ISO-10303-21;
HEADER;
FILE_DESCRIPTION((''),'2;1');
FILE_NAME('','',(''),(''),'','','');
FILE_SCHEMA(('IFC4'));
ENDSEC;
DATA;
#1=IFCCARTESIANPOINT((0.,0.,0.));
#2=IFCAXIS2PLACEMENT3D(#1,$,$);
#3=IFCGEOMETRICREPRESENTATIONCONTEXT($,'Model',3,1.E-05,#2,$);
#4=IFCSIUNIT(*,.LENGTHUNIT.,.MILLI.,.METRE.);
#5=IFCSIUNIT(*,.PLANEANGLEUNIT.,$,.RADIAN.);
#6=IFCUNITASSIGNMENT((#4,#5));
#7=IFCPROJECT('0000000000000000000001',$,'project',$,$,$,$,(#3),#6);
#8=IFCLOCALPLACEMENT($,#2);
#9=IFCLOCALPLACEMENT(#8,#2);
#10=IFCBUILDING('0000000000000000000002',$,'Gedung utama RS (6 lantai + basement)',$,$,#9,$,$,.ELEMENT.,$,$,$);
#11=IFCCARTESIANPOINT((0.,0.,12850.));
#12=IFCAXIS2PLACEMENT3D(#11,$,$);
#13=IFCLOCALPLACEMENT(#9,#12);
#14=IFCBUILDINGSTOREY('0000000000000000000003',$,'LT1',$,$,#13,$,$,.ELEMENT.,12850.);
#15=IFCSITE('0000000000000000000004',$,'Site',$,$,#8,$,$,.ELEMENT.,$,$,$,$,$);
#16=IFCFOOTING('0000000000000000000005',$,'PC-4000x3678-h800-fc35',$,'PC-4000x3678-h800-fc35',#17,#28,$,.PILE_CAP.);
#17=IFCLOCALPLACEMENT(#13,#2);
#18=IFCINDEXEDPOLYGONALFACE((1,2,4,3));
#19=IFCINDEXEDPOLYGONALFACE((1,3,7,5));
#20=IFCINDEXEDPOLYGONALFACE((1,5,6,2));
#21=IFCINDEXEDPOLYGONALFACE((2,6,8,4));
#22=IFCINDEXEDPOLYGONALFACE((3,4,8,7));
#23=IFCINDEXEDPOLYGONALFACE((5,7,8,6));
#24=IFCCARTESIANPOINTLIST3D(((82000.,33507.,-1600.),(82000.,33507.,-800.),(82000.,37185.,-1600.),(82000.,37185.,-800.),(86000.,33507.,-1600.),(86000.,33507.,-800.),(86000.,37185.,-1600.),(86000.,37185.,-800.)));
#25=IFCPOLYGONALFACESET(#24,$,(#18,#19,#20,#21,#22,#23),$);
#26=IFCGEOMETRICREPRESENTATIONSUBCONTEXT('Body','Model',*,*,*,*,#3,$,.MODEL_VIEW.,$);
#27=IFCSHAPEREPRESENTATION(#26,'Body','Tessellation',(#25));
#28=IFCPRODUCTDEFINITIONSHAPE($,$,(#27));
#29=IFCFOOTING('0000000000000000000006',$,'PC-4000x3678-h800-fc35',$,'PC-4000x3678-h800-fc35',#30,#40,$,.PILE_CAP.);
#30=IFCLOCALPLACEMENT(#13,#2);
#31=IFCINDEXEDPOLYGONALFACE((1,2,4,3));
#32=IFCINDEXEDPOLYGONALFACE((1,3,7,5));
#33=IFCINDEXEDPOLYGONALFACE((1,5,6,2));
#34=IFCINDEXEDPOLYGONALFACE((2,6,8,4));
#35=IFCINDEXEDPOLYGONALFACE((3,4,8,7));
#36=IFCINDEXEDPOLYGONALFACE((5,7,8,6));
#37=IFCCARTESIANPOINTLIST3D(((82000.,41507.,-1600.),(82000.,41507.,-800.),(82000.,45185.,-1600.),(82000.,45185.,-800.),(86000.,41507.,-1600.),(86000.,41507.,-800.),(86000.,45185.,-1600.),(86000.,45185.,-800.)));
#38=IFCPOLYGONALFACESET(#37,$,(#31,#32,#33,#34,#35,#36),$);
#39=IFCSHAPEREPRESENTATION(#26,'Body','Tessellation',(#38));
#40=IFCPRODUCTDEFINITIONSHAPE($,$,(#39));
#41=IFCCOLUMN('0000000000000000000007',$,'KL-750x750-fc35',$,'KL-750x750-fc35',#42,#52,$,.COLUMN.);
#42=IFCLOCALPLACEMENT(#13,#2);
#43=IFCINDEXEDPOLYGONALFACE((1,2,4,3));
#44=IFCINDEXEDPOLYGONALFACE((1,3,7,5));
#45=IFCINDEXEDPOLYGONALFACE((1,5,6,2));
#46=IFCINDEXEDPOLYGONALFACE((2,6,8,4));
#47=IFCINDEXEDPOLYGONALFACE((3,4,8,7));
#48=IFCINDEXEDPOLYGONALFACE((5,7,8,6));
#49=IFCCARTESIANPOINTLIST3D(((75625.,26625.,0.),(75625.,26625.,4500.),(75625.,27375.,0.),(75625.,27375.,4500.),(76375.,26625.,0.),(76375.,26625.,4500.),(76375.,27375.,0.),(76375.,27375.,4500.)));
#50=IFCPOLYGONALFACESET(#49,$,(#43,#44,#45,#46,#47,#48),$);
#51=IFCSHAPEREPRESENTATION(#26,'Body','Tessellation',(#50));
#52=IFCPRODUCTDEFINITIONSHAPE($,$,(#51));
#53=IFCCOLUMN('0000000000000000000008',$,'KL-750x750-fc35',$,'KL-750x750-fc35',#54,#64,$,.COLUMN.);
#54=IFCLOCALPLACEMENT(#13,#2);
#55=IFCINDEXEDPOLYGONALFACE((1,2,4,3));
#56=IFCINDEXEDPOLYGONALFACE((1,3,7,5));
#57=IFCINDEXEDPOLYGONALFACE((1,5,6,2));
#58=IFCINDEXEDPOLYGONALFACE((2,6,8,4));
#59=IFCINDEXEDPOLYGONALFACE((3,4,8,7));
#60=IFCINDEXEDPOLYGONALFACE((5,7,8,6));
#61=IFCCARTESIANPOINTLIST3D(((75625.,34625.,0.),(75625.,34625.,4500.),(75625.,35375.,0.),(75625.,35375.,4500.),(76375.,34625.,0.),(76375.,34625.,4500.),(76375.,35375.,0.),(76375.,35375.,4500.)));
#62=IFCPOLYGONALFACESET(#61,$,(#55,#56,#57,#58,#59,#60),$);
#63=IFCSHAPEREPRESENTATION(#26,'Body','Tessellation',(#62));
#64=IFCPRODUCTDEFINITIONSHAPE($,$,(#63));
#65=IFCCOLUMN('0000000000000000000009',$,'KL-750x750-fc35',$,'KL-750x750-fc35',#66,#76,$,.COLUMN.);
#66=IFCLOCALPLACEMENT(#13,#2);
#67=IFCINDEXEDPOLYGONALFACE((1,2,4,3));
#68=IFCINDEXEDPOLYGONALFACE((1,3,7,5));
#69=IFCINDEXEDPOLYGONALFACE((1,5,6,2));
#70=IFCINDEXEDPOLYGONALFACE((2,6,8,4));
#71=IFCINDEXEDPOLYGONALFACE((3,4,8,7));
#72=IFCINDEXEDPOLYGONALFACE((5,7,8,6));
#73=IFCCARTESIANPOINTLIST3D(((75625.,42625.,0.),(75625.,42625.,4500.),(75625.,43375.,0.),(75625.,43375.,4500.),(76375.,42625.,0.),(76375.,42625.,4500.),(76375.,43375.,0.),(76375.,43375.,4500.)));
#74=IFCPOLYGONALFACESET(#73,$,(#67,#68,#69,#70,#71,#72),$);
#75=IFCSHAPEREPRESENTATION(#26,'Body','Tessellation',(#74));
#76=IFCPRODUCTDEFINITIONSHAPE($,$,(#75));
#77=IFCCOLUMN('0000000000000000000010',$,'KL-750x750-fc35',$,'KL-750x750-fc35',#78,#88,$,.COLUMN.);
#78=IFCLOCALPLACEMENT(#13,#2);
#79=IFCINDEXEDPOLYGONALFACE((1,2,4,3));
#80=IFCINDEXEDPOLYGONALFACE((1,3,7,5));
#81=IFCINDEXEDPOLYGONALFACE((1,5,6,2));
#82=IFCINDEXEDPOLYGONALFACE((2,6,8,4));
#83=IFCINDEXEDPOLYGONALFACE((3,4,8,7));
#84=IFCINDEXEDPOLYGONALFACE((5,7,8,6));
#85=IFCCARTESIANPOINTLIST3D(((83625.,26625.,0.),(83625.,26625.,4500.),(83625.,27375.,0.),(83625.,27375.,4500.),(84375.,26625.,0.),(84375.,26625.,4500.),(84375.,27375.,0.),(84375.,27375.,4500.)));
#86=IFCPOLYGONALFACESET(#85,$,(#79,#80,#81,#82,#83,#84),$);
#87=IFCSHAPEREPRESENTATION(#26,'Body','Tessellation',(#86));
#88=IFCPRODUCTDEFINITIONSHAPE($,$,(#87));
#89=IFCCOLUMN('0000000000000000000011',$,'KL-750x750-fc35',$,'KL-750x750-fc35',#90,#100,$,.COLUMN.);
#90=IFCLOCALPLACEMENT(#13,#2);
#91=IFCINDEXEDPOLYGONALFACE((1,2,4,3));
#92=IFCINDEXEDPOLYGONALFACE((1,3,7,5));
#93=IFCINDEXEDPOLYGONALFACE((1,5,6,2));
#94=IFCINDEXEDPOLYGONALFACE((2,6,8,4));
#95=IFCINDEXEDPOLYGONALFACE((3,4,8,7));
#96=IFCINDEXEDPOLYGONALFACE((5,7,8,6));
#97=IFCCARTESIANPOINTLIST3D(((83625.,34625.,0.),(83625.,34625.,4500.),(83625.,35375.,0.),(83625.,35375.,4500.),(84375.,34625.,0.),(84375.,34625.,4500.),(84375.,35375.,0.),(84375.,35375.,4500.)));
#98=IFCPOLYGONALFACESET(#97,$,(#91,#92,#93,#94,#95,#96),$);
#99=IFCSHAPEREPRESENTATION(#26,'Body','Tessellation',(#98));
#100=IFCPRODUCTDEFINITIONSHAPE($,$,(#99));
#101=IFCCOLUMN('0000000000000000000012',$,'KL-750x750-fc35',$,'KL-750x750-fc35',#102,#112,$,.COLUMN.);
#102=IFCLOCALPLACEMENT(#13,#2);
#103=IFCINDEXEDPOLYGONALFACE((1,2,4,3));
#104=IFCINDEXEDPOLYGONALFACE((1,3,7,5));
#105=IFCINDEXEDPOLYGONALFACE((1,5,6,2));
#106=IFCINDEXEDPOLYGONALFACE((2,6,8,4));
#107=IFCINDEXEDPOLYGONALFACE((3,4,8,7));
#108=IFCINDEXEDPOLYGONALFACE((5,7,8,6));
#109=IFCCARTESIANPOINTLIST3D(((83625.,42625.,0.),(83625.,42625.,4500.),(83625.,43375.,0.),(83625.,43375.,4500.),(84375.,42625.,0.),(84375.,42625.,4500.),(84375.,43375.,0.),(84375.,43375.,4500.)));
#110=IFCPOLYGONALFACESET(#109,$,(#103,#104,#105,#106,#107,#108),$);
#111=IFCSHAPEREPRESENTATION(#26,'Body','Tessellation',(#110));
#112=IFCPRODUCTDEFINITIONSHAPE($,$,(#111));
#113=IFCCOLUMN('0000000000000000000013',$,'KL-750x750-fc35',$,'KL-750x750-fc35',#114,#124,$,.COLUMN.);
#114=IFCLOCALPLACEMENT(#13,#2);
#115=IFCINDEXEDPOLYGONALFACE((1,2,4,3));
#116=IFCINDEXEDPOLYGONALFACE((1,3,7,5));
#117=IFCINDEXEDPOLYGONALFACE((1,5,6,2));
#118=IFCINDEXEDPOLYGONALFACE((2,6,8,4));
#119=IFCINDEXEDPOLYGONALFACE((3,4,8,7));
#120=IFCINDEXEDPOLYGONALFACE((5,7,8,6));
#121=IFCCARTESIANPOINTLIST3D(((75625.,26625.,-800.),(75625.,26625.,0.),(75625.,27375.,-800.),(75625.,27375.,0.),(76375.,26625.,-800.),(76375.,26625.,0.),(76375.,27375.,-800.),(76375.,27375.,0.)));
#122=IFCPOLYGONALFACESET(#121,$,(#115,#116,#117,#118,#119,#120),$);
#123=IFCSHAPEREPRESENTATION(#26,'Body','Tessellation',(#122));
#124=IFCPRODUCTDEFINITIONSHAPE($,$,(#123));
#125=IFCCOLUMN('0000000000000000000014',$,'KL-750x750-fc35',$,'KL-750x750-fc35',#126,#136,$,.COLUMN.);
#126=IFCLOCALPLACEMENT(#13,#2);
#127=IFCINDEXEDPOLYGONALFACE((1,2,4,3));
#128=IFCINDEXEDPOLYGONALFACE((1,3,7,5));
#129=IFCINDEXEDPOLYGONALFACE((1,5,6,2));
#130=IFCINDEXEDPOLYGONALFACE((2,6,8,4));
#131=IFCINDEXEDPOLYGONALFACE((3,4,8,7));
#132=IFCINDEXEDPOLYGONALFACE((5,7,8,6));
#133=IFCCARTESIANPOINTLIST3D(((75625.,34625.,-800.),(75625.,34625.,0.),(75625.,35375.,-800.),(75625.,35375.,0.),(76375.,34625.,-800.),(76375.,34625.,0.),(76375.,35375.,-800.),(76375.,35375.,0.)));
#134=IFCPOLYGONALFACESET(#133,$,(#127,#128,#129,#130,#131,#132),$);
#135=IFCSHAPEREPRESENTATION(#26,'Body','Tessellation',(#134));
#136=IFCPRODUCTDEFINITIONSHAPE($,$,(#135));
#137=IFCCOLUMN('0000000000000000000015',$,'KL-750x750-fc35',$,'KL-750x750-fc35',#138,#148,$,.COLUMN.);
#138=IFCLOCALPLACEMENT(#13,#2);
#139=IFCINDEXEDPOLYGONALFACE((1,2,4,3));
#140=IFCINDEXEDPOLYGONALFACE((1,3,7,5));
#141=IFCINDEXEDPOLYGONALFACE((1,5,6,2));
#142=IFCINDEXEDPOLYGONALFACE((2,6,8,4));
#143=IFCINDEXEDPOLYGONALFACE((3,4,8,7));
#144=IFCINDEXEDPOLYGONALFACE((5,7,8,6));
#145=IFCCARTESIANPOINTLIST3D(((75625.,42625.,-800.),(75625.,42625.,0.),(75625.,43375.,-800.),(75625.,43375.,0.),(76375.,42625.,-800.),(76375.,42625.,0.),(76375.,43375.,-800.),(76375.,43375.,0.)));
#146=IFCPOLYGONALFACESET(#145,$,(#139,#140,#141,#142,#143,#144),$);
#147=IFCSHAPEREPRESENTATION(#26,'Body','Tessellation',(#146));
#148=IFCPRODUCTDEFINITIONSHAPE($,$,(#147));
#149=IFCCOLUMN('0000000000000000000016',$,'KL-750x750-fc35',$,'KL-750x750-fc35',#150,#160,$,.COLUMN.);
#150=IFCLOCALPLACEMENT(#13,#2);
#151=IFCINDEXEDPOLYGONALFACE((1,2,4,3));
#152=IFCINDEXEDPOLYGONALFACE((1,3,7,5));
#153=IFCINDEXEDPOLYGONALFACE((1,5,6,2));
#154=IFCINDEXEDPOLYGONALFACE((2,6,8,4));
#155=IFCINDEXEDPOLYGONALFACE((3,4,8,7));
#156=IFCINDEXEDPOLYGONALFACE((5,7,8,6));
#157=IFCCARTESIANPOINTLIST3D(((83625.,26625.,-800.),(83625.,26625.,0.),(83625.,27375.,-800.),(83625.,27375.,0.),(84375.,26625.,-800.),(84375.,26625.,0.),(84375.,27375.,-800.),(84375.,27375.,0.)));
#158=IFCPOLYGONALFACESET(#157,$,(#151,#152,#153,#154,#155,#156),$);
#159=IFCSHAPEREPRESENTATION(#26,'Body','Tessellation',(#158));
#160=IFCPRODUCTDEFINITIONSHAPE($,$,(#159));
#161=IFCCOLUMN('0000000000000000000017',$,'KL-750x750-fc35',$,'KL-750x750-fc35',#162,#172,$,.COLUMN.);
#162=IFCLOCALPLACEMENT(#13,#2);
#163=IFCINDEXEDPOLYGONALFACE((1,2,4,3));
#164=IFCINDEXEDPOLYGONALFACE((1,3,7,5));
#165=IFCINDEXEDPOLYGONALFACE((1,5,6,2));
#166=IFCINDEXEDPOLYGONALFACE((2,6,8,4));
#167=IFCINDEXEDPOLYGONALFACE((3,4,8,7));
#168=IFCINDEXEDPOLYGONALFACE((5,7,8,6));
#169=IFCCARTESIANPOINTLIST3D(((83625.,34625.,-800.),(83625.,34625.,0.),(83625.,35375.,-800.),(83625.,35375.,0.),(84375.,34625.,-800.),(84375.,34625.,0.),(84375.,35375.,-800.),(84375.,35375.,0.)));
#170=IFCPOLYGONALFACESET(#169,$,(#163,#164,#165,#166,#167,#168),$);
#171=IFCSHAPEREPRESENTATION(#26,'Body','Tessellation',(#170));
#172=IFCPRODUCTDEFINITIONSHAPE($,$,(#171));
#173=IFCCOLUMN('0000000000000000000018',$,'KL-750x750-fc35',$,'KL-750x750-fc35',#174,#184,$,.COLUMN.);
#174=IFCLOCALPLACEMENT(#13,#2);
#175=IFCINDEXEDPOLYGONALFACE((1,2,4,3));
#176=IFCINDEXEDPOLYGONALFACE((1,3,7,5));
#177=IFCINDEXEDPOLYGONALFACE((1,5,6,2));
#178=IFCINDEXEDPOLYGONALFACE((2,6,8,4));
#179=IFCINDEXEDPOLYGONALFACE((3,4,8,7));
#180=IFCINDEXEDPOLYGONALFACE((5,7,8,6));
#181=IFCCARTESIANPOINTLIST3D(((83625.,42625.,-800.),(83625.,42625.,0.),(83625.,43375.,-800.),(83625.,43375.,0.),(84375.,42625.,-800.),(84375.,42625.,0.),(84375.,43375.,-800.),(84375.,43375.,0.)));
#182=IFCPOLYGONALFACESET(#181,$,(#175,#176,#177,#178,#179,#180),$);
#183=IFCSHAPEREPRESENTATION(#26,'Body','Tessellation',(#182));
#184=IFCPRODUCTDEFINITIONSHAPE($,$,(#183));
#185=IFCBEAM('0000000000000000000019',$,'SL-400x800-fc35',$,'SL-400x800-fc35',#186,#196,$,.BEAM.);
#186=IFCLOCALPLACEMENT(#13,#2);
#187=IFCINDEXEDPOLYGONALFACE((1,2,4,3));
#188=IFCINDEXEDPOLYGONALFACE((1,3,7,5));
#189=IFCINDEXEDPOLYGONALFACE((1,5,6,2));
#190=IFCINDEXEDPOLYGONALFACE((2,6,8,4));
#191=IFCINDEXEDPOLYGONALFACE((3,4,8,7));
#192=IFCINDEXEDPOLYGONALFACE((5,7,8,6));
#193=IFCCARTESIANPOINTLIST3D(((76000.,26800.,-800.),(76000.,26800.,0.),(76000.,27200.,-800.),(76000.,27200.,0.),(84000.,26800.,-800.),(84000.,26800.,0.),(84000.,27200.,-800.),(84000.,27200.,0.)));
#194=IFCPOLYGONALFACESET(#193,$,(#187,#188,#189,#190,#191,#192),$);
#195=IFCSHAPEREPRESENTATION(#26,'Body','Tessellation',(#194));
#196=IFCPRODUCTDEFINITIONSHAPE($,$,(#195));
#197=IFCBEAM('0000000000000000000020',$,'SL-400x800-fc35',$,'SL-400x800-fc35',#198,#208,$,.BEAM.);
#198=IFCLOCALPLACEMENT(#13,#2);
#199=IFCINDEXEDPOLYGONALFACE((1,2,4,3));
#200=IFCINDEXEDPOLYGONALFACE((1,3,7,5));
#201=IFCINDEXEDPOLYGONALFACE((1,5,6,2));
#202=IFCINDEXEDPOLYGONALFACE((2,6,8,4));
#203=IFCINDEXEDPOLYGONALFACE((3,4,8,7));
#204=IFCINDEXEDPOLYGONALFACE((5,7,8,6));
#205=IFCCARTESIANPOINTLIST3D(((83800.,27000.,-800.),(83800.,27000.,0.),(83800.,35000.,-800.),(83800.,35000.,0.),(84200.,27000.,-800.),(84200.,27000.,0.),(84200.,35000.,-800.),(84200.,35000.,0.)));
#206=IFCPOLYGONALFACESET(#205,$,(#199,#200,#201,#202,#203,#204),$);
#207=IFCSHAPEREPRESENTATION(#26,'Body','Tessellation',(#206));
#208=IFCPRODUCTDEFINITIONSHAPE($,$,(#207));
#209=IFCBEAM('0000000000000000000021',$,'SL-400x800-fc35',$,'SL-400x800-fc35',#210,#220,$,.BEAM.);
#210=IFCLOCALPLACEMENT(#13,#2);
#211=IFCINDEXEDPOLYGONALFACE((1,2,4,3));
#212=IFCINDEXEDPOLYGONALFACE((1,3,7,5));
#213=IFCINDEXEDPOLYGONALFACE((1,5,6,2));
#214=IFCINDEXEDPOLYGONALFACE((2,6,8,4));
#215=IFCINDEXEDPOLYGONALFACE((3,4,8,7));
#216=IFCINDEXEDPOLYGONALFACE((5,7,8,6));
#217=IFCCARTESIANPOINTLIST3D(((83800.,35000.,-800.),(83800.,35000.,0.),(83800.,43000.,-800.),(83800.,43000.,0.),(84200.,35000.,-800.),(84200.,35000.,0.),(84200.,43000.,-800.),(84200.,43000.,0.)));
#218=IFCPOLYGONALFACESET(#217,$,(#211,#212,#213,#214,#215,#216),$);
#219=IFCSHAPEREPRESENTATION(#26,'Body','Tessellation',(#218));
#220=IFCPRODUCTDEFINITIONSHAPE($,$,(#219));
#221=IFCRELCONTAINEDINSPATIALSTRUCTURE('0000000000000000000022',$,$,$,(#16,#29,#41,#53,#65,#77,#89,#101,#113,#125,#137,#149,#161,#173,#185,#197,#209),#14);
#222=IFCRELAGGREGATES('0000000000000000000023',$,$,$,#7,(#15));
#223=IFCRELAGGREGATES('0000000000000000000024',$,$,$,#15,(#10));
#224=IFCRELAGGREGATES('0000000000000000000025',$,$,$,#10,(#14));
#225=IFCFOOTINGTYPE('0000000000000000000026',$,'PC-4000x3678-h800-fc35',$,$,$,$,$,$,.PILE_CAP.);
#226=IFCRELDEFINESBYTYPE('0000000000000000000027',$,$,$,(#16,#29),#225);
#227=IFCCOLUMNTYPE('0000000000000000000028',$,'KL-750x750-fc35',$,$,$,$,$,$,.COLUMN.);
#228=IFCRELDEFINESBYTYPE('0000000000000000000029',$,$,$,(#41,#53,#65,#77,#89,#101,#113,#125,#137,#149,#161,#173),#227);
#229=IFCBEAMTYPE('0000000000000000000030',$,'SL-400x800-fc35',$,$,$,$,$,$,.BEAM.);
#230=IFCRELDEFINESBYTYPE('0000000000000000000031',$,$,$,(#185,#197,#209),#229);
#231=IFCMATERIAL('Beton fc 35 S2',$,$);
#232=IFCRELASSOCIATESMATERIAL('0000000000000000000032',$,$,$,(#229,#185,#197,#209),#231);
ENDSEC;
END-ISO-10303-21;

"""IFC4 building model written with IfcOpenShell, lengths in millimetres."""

from ifc_helpers import new_model, si_unit, frame, origin, origin_2d, place, context, subcontext, project, spatial, rectangle, extrude, material, material_profile, profile_set, profile_usage, type_object, element, save


model = new_model("IFC4")

# Units and contexts
model_context = context("Model", 3, precision=1e-05, world=origin())
body_context = subcontext(model_context, "Body", "Model", "MODEL_VIEW")
ifc_project = project(units=[si_unit("LENGTHUNIT", "METRE", prefix="MILLI"), si_unit("PLANEANGLEUNIT", "RADIAN")], contexts=[model_context])

# Site, building, storey
site_placement = place(None, origin())
site = spatial("IfcSite", under=ifc_project, at=site_placement, Name="Site", CompositionType="ELEMENT")
building_placement = place(site_placement, origin())
building = spatial("IfcBuilding", under=site, at=building_placement, Name="Gedung utama RS (6 lantai + basement)", CompositionType="ELEMENT")
storey_placement = place(building_placement, frame((0.0, 0.0, 12850.0)))
storey = spatial("IfcBuildingStorey", under=building, at=storey_placement, Name="LT1", CompositionType="ELEMENT", Elevation=12850.0)

# Footings
ifc_material_profile_1 = material_profile(None, rectangle(XDim=4000.0, YDim=3678.0, at=origin_2d()), Name="PC-4000x3678-h800-fc35")
ifc_profile_set_1 = profile_set([ifc_material_profile_1], Name="PC-4000x3678-h800-fc35")
ifc_profile_usage_1 = profile_usage(ifc_profile_set_1, cardinal=5)
footing_type = type_object("IfcFootingType", Name="PC-4000x3678-h800-fc35", PredefinedType="PILE_CAP", material=ifc_profile_set_1)
for number, where, z_axis, x_axis, name in (
    (1, (84000.0, 35346.0, -1600.0), (0.0, 0.0, 1.0), (1.0, 0.0, 0.0), "PC-4000x3678-h800-fc35"),
    (2, (84000.0, 43346.0, -1600.0), (0.0, 0.0, 1.0), (1.0, 0.0, 0.0), "PC-4000x3678-h800-fc35"),
):
    element("IfcFooting", number, at=place(storey_placement, frame(where, z_axis=z_axis, x_axis=x_axis)), inside=storey, type_object=footing_type, material=ifc_profile_usage_1, Name=name, ObjectType="PC-4000x3678-h800-fc35", PredefinedType="PILE_CAP", context=body_context, shape_type="SweptSolid", body=[
        extrude(rectangle(XDim=4000.0, YDim=3678.0, at=origin_2d()), origin(), (0.0, 0.0, 1.0), 800.0),
    ])

# Columns
ifc_material_profile_2 = material_profile(None, rectangle(XDim=750.0, YDim=750.0, at=origin_2d()), Name="KL-750x750-fc35")
ifc_profile_set_2 = profile_set([ifc_material_profile_2], Name="KL-750x750-fc35")
ifc_profile_usage_2 = profile_usage(ifc_profile_set_2, cardinal=5)
column_type = type_object("IfcColumnType", Name="KL-750x750-fc35", PredefinedType="COLUMN", material=ifc_profile_set_2)
for number, where, z_axis, x_axis, name in (
    (3, (76000.0, 27000.0, 0.0), (0.0, 0.0, 1.0), (1.0, 0.0, 0.0), "KL-750x750-fc35"),
    (4, (76000.0, 35000.0, 0.0), (0.0, 0.0, 1.0), (1.0, 0.0, 0.0), "KL-750x750-fc35"),
    (5, (76000.0, 43000.0, 0.0), (0.0, 0.0, 1.0), (1.0, 0.0, 0.0), "KL-750x750-fc35"),
    (6, (84000.0, 27000.0, 0.0), (0.0, 0.0, 1.0), (1.0, 0.0, 0.0), "KL-750x750-fc35"),
    (7, (84000.0, 35000.0, 0.0), (0.0, 0.0, 1.0), (1.0, 0.0, 0.0), "KL-750x750-fc35"),
    (8, (84000.0, 43000.0, 0.0), (0.0, 0.0, 1.0), (1.0, 0.0, 0.0), "KL-750x750-fc35"),
):
    element("IfcColumn", number, at=place(storey_placement, frame(where, z_axis=z_axis, x_axis=x_axis)), inside=storey, type_object=column_type, material=ifc_profile_usage_2, Name=name, ObjectType="KL-750x750-fc35", PredefinedType="COLUMN", context=body_context, shape_type="SweptSolid", body=[
        extrude(rectangle(XDim=750.0, YDim=750.0, at=origin_2d()), origin(), (0.0, 0.0, 1.0), 4500.0),
    ])
for number, where, z_axis, x_axis, name in (
    (9, (76000.0, 27000.0, -800.0), (0.0, 0.0, 1.0), (1.0, 0.0, 0.0), "KL-750x750-fc35"),
    (10, (76000.0, 35000.0, -800.0), (0.0, 0.0, 1.0), (1.0, 0.0, 0.0), "KL-750x750-fc35"),
    (11, (76000.0, 43000.0, -800.0), (0.0, 0.0, 1.0), (1.0, 0.0, 0.0), "KL-750x750-fc35"),
    (12, (84000.0, 27000.0, -800.0), (0.0, 0.0, 1.0), (1.0, 0.0, 0.0), "KL-750x750-fc35"),
    (13, (84000.0, 35000.0, -800.0), (0.0, 0.0, 1.0), (1.0, 0.0, 0.0), "KL-750x750-fc35"),
    (14, (84000.0, 43000.0, -800.0), (0.0, 0.0, 1.0), (1.0, 0.0, 0.0), "KL-750x750-fc35"),
):
    element("IfcColumn", number, at=place(storey_placement, frame(where, z_axis=z_axis, x_axis=x_axis)), inside=storey, type_object=column_type, material=ifc_profile_usage_2, Name=name, ObjectType="KL-750x750-fc35", PredefinedType="COLUMN", context=body_context, shape_type="SweptSolid", body=[
        extrude(rectangle(XDim=750.0, YDim=750.0, at=origin_2d()), origin(), (0.0, 0.0, 1.0), 800.0),
    ])

# Beams
ifc_material = material(Name="Beton fc 35 S2")
ifc_material_profile_3 = material_profile(ifc_material, rectangle(XDim=400.0, YDim=800.0, at=origin_2d()), Name="SL-400x800-fc35")
ifc_profile_set_3 = profile_set([ifc_material_profile_3], Name="SL-400x800-fc35")
ifc_profile_usage_3 = profile_usage(ifc_profile_set_3, cardinal=8)
beam_type_1 = type_object("IfcBeamType", Name="SL-400x800-fc35", PredefinedType="BEAM", material=ifc_profile_set_3)
beam_1_placement = place(storey_placement, frame((76000.0, 27000.0, -400.0)))
element("IfcBeam", 15, at=beam_1_placement, inside=storey, type_object=beam_type_1, material=ifc_profile_usage_3, Name="SL-400x800-fc35", ObjectType="SL-400x800-fc35", PredefinedType="BEAM", context=body_context, shape_type="SweptSolid", body=[
    extrude(rectangle(XDim=400.0, YDim=800.0, at=origin_2d()), frame((0.0, 0.0, 0.0), z_axis=(1.0, 0.0, 0.0), x_axis=(0.0, 1.0, 0.0)), (0.0, 0.0, 1.0), 8000.0),
])
for number, where, name in (
    (16, (84000.0, 27000.0, -400.0), "SL-400x800-fc35"),
    (17, (84000.0, 35000.0, -400.0), "SL-400x800-fc35"),
):
    element("IfcBeam", number, at=place(storey_placement, frame(where)), inside=storey, type_object=beam_type_1, material=ifc_profile_usage_3, Name=name, ObjectType="SL-400x800-fc35", PredefinedType="BEAM", context=body_context, shape_type="SweptSolid", body=[
        extrude(rectangle(XDim=400.0, YDim=800.0, at=origin_2d()), frame((0.0, 0.0, 0.0), z_axis=(0.0, 1.0, 0.0), x_axis=(-1.0, 0.0, 0.0)), (0.0, 0.0, 1.0), 8000.0),
    ])

save(model, "model.ifc")
